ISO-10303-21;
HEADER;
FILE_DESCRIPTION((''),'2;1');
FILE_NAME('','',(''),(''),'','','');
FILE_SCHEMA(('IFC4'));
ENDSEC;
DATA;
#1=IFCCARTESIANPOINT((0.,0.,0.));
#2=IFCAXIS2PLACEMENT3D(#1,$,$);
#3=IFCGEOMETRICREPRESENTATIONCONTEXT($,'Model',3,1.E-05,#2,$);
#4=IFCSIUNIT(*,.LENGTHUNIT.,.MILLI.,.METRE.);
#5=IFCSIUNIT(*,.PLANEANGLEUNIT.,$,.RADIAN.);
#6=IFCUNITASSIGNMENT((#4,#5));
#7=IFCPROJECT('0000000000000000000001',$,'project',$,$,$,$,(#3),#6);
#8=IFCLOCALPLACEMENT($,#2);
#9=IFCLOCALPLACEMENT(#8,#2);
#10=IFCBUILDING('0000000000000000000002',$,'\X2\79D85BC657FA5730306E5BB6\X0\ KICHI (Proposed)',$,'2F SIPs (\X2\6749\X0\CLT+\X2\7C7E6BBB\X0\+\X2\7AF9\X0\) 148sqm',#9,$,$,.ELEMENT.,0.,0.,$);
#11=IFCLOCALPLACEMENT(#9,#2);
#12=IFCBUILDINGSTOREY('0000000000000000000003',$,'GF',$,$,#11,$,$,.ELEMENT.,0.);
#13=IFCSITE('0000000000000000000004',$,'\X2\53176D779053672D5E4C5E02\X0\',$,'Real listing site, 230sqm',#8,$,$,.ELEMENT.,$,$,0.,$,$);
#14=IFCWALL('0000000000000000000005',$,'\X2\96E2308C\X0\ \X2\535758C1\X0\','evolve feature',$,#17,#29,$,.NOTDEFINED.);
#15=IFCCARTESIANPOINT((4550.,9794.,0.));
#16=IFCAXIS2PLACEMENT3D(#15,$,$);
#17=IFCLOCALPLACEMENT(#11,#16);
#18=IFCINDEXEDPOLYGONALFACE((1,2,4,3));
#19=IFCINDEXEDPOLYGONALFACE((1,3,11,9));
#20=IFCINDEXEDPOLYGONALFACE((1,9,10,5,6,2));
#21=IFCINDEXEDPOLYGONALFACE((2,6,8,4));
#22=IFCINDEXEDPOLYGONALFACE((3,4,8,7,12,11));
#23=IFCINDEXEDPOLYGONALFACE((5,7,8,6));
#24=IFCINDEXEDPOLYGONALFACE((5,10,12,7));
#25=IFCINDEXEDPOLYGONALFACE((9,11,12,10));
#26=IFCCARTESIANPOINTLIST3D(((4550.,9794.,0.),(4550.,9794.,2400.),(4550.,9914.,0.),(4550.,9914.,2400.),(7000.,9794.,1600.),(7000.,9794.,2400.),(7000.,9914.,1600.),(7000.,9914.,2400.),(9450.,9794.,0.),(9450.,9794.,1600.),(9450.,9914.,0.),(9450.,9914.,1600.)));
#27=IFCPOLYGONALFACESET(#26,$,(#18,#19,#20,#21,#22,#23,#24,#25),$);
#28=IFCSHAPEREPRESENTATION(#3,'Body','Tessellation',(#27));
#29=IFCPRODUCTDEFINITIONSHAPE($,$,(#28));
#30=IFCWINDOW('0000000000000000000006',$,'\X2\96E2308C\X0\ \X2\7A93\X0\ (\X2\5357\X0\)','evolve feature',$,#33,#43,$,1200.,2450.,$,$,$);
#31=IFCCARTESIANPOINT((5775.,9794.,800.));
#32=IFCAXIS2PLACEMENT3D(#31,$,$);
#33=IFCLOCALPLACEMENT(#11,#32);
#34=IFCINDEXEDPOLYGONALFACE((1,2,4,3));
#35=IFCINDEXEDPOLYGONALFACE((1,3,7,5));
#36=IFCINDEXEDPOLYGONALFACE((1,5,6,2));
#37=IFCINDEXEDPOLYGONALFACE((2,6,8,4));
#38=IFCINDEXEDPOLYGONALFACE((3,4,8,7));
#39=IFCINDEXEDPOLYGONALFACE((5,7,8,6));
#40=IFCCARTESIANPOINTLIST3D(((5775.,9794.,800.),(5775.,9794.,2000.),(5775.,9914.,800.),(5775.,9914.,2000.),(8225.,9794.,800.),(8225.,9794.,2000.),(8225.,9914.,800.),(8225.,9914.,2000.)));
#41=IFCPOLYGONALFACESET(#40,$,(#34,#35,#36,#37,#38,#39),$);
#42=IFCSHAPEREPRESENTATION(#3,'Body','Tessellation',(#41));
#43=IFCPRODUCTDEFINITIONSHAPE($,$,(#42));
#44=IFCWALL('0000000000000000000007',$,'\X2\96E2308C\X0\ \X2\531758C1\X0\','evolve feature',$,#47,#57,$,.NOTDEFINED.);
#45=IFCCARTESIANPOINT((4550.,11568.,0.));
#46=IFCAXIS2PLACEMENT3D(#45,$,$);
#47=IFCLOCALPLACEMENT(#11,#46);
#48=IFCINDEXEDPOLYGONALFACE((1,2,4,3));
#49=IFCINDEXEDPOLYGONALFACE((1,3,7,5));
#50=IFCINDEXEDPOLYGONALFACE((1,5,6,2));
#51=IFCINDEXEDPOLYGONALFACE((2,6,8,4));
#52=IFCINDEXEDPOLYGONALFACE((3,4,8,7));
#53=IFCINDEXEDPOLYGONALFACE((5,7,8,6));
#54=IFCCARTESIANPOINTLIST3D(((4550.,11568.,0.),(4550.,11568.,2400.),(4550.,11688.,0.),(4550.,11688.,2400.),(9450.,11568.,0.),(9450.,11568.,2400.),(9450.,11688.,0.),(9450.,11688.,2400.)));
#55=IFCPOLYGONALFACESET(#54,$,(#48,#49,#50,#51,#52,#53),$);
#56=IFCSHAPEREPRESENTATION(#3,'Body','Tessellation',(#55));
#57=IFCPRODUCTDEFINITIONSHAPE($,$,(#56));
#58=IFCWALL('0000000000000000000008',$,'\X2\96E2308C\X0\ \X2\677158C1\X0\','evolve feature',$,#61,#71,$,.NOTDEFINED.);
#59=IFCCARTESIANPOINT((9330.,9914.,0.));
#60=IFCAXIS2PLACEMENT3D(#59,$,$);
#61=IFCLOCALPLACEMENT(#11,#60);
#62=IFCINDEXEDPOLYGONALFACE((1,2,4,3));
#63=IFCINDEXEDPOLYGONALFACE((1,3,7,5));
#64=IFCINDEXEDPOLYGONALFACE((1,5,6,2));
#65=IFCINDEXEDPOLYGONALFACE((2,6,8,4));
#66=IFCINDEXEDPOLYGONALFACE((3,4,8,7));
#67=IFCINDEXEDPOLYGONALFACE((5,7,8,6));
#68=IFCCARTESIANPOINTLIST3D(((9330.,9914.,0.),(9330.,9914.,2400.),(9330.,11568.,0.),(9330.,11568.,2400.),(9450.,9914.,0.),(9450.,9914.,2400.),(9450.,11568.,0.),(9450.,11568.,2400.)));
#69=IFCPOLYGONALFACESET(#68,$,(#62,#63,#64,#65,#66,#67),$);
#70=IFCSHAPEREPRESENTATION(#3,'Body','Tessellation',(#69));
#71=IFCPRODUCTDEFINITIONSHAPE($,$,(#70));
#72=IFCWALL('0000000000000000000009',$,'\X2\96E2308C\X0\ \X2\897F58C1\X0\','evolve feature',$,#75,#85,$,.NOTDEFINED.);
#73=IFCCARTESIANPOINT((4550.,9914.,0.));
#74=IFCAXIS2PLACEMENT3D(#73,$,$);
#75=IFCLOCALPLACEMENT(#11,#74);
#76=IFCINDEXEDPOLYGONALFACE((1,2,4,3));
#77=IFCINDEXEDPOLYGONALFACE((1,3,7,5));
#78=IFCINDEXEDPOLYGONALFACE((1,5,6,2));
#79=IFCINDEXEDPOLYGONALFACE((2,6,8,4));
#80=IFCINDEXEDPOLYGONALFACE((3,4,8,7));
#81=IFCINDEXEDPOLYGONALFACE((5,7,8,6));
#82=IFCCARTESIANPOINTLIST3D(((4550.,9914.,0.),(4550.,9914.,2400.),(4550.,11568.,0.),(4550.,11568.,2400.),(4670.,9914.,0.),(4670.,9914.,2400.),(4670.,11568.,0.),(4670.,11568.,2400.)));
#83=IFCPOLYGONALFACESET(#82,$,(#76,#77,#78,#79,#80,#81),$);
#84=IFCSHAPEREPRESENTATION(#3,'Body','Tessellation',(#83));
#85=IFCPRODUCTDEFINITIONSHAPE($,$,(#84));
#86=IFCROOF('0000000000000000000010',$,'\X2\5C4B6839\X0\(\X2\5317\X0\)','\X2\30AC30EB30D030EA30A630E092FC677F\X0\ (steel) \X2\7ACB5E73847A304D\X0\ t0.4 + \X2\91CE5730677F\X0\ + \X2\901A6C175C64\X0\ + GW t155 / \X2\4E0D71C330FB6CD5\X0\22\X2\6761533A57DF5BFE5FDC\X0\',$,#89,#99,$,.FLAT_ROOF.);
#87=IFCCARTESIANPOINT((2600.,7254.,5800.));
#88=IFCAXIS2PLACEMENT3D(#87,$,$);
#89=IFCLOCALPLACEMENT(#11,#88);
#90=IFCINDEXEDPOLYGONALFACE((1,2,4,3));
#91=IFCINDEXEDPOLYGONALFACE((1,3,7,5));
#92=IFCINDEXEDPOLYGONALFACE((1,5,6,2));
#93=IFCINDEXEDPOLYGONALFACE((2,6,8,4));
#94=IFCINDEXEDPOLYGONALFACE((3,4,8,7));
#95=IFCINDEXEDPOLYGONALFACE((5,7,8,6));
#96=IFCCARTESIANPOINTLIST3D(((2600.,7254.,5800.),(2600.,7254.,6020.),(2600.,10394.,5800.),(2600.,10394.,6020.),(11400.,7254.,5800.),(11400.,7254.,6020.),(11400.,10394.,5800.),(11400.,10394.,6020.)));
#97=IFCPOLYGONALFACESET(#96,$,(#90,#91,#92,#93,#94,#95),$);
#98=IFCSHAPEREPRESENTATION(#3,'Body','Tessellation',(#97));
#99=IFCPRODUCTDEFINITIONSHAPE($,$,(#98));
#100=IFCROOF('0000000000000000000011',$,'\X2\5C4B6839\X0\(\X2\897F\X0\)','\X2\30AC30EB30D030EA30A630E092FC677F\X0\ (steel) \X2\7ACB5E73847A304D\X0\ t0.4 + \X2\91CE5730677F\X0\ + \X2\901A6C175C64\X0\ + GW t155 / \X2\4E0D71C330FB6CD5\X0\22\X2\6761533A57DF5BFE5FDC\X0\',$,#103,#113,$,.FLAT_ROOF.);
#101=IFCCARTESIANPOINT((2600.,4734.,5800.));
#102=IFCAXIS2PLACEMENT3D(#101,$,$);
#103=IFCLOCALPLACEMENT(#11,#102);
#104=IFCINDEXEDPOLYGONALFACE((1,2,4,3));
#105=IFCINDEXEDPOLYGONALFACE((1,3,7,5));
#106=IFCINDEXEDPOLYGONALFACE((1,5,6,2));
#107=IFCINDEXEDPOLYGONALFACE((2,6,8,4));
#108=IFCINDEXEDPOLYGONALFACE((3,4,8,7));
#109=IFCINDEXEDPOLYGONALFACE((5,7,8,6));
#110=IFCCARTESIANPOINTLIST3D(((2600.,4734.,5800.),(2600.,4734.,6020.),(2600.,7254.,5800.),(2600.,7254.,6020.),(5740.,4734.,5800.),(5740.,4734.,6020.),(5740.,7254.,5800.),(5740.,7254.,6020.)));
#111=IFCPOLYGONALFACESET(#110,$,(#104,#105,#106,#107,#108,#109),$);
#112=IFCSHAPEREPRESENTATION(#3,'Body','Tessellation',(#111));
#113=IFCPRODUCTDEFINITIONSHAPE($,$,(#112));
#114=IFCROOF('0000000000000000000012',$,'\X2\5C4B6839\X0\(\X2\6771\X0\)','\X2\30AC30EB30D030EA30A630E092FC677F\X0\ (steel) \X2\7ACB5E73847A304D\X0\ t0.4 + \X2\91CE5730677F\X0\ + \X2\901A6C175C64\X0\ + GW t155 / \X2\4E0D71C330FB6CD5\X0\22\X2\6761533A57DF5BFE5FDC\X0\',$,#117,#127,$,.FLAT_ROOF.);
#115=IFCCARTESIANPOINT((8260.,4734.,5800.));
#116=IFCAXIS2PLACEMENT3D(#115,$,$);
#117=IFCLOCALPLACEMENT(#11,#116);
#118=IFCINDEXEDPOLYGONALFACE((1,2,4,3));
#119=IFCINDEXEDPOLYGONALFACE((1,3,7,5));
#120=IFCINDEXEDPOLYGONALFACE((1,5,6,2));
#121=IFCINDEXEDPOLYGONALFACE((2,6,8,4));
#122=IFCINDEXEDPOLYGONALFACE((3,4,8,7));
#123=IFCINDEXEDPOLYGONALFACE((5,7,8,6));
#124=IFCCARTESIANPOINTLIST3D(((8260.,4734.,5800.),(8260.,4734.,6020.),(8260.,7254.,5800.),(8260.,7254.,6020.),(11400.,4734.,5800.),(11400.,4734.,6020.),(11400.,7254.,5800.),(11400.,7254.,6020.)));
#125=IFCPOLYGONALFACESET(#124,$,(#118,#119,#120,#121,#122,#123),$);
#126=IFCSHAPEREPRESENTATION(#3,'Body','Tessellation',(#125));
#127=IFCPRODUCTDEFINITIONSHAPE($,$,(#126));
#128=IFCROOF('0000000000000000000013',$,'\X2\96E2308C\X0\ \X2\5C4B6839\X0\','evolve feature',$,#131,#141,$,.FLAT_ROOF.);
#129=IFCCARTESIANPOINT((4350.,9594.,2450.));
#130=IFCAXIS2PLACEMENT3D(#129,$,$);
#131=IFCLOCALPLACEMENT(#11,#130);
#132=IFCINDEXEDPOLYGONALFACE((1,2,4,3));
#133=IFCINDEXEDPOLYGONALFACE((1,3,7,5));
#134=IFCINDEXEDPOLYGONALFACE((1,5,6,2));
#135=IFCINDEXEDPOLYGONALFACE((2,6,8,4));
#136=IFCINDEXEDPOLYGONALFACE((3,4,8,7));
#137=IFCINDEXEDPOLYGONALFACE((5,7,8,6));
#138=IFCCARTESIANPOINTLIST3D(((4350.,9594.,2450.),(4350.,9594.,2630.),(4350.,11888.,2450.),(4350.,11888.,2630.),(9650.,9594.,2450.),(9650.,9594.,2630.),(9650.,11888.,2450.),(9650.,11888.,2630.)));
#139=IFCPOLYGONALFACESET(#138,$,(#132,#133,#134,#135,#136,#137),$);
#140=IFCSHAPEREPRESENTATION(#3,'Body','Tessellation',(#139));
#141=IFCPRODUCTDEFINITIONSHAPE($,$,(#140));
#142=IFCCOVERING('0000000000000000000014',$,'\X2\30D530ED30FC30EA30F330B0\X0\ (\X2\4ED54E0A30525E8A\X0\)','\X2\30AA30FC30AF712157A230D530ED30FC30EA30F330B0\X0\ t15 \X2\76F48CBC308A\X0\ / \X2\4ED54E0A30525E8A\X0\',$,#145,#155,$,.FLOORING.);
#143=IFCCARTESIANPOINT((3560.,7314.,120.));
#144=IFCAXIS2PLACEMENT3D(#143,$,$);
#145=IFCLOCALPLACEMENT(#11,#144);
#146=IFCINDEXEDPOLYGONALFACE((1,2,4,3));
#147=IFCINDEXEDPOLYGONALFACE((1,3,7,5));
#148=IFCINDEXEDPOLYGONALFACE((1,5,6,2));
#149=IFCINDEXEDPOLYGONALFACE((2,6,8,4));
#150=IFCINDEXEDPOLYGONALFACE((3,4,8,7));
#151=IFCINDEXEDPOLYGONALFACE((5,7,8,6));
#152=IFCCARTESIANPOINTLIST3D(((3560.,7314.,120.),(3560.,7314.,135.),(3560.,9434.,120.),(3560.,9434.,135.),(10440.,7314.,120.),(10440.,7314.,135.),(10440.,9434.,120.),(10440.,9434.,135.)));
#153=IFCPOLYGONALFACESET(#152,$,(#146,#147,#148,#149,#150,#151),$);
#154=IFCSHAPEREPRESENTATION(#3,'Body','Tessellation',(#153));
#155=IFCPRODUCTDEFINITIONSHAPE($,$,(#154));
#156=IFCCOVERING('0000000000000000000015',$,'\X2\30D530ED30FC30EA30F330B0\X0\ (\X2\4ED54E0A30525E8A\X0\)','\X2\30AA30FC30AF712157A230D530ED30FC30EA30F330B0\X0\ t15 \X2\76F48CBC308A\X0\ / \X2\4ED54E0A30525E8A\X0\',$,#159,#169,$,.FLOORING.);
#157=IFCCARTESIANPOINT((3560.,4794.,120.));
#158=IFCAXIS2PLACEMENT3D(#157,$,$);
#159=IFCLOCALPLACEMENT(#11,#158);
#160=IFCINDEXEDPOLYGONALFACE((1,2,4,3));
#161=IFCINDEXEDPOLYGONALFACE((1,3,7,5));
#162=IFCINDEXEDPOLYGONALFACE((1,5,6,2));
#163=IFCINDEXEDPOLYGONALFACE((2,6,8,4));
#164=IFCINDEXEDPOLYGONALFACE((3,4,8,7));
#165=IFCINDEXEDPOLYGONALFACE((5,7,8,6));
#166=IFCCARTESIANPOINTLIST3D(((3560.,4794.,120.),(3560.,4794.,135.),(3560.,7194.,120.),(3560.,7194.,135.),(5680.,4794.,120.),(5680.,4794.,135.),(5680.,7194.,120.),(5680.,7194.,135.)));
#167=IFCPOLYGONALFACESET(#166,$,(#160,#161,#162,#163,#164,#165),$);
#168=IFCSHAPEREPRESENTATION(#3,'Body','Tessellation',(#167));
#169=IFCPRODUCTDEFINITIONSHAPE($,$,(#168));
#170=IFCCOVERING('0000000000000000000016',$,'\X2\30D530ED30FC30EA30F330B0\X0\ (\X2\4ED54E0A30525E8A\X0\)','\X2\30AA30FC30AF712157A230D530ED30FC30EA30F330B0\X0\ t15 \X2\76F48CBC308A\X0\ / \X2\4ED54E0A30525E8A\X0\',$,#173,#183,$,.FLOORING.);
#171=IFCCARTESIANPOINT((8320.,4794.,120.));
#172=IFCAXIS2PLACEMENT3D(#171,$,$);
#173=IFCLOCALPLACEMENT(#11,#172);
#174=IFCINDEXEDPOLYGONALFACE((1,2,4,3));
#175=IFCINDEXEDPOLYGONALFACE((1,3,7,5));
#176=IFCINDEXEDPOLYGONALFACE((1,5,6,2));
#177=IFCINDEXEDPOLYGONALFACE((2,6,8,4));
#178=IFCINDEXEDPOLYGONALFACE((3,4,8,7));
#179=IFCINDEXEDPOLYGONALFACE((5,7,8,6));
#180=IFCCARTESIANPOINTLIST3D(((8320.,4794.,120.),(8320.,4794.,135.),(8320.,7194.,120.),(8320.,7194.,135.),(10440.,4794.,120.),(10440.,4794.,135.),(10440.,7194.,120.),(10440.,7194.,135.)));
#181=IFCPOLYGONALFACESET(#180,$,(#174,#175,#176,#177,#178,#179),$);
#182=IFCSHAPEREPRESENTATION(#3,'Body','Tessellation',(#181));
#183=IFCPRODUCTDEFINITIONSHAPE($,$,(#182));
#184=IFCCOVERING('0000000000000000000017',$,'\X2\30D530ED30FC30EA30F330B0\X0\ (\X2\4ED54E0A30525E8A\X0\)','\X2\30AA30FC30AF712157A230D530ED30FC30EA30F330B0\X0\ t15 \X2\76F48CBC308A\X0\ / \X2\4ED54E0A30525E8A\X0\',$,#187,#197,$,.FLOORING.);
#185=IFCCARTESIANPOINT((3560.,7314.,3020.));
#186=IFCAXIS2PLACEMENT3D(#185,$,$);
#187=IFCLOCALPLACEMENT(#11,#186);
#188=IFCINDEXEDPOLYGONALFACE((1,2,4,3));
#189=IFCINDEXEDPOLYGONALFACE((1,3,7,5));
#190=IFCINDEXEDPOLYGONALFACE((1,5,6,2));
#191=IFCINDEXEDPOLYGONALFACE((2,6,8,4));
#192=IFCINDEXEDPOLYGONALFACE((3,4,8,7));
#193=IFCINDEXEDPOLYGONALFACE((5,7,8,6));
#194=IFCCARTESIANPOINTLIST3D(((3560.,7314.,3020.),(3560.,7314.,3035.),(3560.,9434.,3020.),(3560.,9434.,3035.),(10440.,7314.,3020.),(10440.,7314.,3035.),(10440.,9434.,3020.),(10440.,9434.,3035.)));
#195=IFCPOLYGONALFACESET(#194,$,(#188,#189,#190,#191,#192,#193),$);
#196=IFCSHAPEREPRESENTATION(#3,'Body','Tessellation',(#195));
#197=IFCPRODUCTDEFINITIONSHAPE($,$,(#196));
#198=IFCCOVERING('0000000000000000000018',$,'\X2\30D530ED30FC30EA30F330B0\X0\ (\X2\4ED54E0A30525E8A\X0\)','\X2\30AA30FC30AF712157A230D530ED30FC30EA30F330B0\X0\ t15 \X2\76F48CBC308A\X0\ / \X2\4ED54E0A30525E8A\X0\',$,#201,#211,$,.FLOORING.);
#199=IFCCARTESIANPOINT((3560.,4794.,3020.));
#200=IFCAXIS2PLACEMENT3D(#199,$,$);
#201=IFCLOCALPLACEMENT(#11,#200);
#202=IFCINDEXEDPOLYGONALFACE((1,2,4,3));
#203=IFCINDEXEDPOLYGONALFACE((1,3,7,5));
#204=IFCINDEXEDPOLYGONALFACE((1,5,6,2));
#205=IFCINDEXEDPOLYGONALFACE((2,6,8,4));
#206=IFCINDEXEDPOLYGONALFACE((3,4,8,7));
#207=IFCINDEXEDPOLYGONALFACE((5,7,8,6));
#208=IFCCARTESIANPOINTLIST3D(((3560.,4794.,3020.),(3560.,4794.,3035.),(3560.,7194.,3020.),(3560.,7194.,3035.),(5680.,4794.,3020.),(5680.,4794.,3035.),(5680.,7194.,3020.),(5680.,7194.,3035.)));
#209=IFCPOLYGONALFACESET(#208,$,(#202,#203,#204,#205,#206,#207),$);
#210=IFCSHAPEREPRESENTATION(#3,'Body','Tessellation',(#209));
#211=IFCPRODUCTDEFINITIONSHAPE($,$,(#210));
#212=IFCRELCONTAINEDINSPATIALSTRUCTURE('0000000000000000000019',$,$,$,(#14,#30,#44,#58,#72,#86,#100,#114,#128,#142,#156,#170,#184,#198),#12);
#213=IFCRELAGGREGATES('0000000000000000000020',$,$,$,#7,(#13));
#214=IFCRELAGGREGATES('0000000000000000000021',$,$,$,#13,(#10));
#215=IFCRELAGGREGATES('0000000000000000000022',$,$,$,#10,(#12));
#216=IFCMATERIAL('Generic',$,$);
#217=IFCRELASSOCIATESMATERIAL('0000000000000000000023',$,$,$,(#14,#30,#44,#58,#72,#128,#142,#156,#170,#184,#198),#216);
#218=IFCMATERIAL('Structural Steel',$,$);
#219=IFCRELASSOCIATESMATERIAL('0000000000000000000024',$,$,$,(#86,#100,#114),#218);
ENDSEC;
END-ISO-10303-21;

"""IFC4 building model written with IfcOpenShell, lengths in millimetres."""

from ifc_helpers import new_model, si_unit, frame, frame_2d, origin, place, context, project, spatial, rectangle, extrude, material, element, fill, save


model = new_model("IFC4")

# Units and contexts
model_context = context("Model", 3, precision=1e-05, world=origin())
ifc_project = project(units=[si_unit("LENGTHUNIT", "METRE", prefix="MILLI"), si_unit("PLANEANGLEUNIT", "RADIAN")], contexts=[model_context])

# Site, building, storey
site_placement = place(None, origin())
site = spatial("IfcSite", under=ifc_project, at=site_placement, Name="北海道札幌市", ObjectType="Real listing site, 230sqm", CompositionType="ELEMENT", RefElevation=0.0)
building_placement = place(site_placement, origin())
building = spatial("IfcBuilding", under=site, at=building_placement, Name="秘密基地の家 KICHI (Proposed)", ObjectType="2F SIPs (杉CLT+籾殻+竹) 148sqm", CompositionType="ELEMENT", ElevationOfRefHeight=0.0, ElevationOfTerrain=0.0)
storey_placement = place(building_placement, origin())
storey = spatial("IfcBuildingStorey", under=building, at=storey_placement, Name="GF", CompositionType="ELEMENT", Elevation=0.0)

# Shared definitions
ifc_material_1 = material(Name="Generic")

# Wall, opening, window
wall_1_placement = place(storey_placement, frame((4550.0, 9794.0, 0.0)))
wall_1 = element("IfcWall", 1, at=wall_1_placement, inside=storey, material=ifc_material_1, Name="離れ 南壁", Description="evolve feature", PredefinedType="NOTDEFINED", context=model_context, shape_type="SweptSolid", body=[
    extrude(rectangle(XDim=4900.0, YDim=120.0, at=frame_2d((2450.0, 60.0))), frame((4550.0, 9794.0, 0.0)), (0.0, 0.0, 1.0), 2400.0),
])
opening_1_placement = place(storey_placement, frame((5775.0, 9794.0, 800.0)))
opening_1 = element("IfcOpeningElement", 2, at=opening_1_placement, cuts=wall_1, PredefinedType="NOTDEFINED", context=model_context, shape_type="SweptSolid", body=[
    extrude(rectangle(XDim=2450.0, YDim=120.0, at=frame_2d((1225.0, 60.0))), frame((5775.0, 9794.0, 800.0)), (0.0, 0.0, 1.0), 1200.0),
])
window_1_placement = place(storey_placement, frame((5775.0, 9794.0, 800.0)))
window_1 = element("IfcWindow", 3, at=window_1_placement, inside=storey, material=ifc_material_1, Name="離れ 窓 (南)", Description="evolve feature", OverallHeight=1200.0, OverallWidth=2450.0, context=model_context, shape_type="SweptSolid", body=[
    extrude(rectangle(XDim=2450.0, YDim=120.0, at=frame_2d((1225.0, 60.0))), frame((5775.0, 9794.0, 800.0)), (0.0, 0.0, 1.0), 1200.0),
])
fill(opening_1, window_1)

# Walls
wall_2_placement = place(storey_placement, frame((4550.0, 11568.0, 0.0)))
element("IfcWall", 4, at=wall_2_placement, inside=storey, material=ifc_material_1, Name="離れ 北壁", Description="evolve feature", PredefinedType="NOTDEFINED", context=model_context, shape_type="SweptSolid", body=[
    extrude(rectangle(XDim=4900.0, YDim=120.0, at=frame_2d((2450.0, 60.0))), frame((4550.0, 11568.0, 0.0)), (0.0, 0.0, 1.0), 2400.0),
])
wall_3_placement = place(storey_placement, frame((9330.0, 9914.0, 0.0)))
element("IfcWall", 5, at=wall_3_placement, inside=storey, material=ifc_material_1, Name="離れ 東壁", Description="evolve feature", PredefinedType="NOTDEFINED", context=model_context, shape_type="SweptSolid", body=[
    extrude(rectangle(XDim=120.0, YDim=1654.0, at=frame_2d((60.0, 827.0))), frame((9330.0, 9914.0, 0.0)), (0.0, 0.0, 1.0), 2400.0),
])
wall_4_placement = place(storey_placement, frame((4550.0, 9914.0, 0.0)))
element("IfcWall", 6, at=wall_4_placement, inside=storey, material=ifc_material_1, Name="離れ 西壁", Description="evolve feature", PredefinedType="NOTDEFINED", context=model_context, shape_type="SweptSolid", body=[
    extrude(rectangle(XDim=120.0, YDim=1654.0, at=frame_2d((60.0, 827.0))), frame((4550.0, 9914.0, 0.0)), (0.0, 0.0, 1.0), 2400.0),
])

# Roofs
ifc_material_2 = material(Name="Structural Steel")
for number, where, name in (
    (7, (2600.0, 7254.0, 5800.0), "屋根(北)"),
):
    element("IfcRoof", number, at=place(storey_placement, frame(where)), inside=storey, material=ifc_material_2, Name=name, Description="ガルバリウム鋼板 (steel) 立平葺き t0.4 + 野地板 + 通気層 + GW t155 / 不燃・法22条区域対応", PredefinedType="FLAT_ROOF", context=model_context, shape_type="SweptSolid", body=[
        extrude(rectangle(XDim=8800.0, YDim=3140.0, at=frame_2d((4400.0, 1570.0))), frame((2600.0, 7254.0, 5800.0)), (0.0, 0.0, 1.0), 220.0),
    ])
roof_1_placement = place(storey_placement, frame((2600.0, 4734.0, 5800.0)))
element("IfcRoof", 8, at=roof_1_placement, inside=storey, material=ifc_material_2, Name="屋根(西)", Description="ガルバリウム鋼板 (steel) 立平葺き t0.4 + 野地板 + 通気層 + GW t155 / 不燃・法22条区域対応", PredefinedType="FLAT_ROOF", context=model_context, shape_type="SweptSolid", body=[
    extrude(rectangle(XDim=3140.0, YDim=2520.0, at=frame_2d((1570.0, 1260.0))), frame((2600.0, 4734.0, 5800.0)), (0.0, 0.0, 1.0), 220.0),
])
roof_2_placement = place(storey_placement, frame((8260.0, 4734.0, 5800.0)))
element("IfcRoof", 9, at=roof_2_placement, inside=storey, material=ifc_material_2, Name="屋根(東)", Description="ガルバリウム鋼板 (steel) 立平葺き t0.4 + 野地板 + 通気層 + GW t155 / 不燃・法22条区域対応", PredefinedType="FLAT_ROOF", context=model_context, shape_type="SweptSolid", body=[
    extrude(rectangle(XDim=3140.0, YDim=2520.0, at=frame_2d((1570.0, 1260.0))), frame((8260.0, 4734.0, 5800.0)), (0.0, 0.0, 1.0), 220.0),
])
roof_3_placement = place(storey_placement, frame((4350.0, 9594.0, 2450.0)))
element("IfcRoof", 10, at=roof_3_placement, inside=storey, material=ifc_material_1, Name="離れ 屋根", Description="evolve feature", PredefinedType="FLAT_ROOF", context=model_context, shape_type="SweptSolid", body=[
    extrude(rectangle(XDim=5300.0, YDim=2294.0, at=frame_2d((2650.0, 1147.0))), frame((4350.0, 9594.0, 2450.0)), (0.0, 0.0, 1.0), 180.0),
])

# Coverings
covering_1_placement = place(storey_placement, frame((3560.0, 7314.0, 120.0)))
element("IfcCovering", 11, at=covering_1_placement, inside=storey, material=ifc_material_1, Name="フローリング (仕上げ床)", Description="オーク無垢フローリング t15 直貼り / 仕上げ床", PredefinedType="FLOORING", context=model_context, shape_type="SweptSolid", body=[
    extrude(rectangle(XDim=6880.0, YDim=2120.0, at=frame_2d((3440.0, 1060.0))), frame((3560.0, 7314.0, 120.0)), (0.0, 0.0, 1.0), 15.0),
])
covering_2_placement = place(storey_placement, frame((3560.0, 4794.0, 120.0)))
element("IfcCovering", 12, at=covering_2_placement, inside=storey, material=ifc_material_1, Name="フローリング (仕上げ床)", Description="オーク無垢フローリング t15 直貼り / 仕上げ床", PredefinedType="FLOORING", context=model_context, shape_type="SweptSolid", body=[
    extrude(rectangle(XDim=2120.0, YDim=2400.0, at=frame_2d((1060.0, 1200.0))), frame((3560.0, 4794.0, 120.0)), (0.0, 0.0, 1.0), 15.0),
])
covering_3_placement = place(storey_placement, frame((8320.0, 4794.0, 120.0)))
element("IfcCovering", 13, at=covering_3_placement, inside=storey, material=ifc_material_1, Name="フローリング (仕上げ床)", Description="オーク無垢フローリング t15 直貼り / 仕上げ床", PredefinedType="FLOORING", context=model_context, shape_type="SweptSolid", body=[
    extrude(rectangle(XDim=2120.0, YDim=2400.0, at=frame_2d((1060.0, 1200.0))), frame((8320.0, 4794.0, 120.0)), (0.0, 0.0, 1.0), 15.0),
])
covering_4_placement = place(storey_placement, frame((3560.0, 7314.0, 3020.0)))
element("IfcCovering", 14, at=covering_4_placement, inside=storey, material=ifc_material_1, Name="フローリング (仕上げ床)", Description="オーク無垢フローリング t15 直貼り / 仕上げ床", PredefinedType="FLOORING", context=model_context, shape_type="SweptSolid", body=[
    extrude(rectangle(XDim=6880.0, YDim=2120.0, at=frame_2d((3440.0, 1060.0))), frame((3560.0, 7314.0, 3020.0)), (0.0, 0.0, 1.0), 15.0),
])
covering_5_placement = place(storey_placement, frame((3560.0, 4794.0, 3020.0)))
element("IfcCovering", 15, at=covering_5_placement, inside=storey, material=ifc_material_1, Name="フローリング (仕上げ床)", Description="オーク無垢フローリング t15 直貼り / 仕上げ床", PredefinedType="FLOORING", context=model_context, shape_type="SweptSolid", body=[
    extrude(rectangle(XDim=2120.0, YDim=2400.0, at=frame_2d((1060.0, 1200.0))), frame((3560.0, 4794.0, 3020.0)), (0.0, 0.0, 1.0), 15.0),
])

save(model, "model.ifc")
